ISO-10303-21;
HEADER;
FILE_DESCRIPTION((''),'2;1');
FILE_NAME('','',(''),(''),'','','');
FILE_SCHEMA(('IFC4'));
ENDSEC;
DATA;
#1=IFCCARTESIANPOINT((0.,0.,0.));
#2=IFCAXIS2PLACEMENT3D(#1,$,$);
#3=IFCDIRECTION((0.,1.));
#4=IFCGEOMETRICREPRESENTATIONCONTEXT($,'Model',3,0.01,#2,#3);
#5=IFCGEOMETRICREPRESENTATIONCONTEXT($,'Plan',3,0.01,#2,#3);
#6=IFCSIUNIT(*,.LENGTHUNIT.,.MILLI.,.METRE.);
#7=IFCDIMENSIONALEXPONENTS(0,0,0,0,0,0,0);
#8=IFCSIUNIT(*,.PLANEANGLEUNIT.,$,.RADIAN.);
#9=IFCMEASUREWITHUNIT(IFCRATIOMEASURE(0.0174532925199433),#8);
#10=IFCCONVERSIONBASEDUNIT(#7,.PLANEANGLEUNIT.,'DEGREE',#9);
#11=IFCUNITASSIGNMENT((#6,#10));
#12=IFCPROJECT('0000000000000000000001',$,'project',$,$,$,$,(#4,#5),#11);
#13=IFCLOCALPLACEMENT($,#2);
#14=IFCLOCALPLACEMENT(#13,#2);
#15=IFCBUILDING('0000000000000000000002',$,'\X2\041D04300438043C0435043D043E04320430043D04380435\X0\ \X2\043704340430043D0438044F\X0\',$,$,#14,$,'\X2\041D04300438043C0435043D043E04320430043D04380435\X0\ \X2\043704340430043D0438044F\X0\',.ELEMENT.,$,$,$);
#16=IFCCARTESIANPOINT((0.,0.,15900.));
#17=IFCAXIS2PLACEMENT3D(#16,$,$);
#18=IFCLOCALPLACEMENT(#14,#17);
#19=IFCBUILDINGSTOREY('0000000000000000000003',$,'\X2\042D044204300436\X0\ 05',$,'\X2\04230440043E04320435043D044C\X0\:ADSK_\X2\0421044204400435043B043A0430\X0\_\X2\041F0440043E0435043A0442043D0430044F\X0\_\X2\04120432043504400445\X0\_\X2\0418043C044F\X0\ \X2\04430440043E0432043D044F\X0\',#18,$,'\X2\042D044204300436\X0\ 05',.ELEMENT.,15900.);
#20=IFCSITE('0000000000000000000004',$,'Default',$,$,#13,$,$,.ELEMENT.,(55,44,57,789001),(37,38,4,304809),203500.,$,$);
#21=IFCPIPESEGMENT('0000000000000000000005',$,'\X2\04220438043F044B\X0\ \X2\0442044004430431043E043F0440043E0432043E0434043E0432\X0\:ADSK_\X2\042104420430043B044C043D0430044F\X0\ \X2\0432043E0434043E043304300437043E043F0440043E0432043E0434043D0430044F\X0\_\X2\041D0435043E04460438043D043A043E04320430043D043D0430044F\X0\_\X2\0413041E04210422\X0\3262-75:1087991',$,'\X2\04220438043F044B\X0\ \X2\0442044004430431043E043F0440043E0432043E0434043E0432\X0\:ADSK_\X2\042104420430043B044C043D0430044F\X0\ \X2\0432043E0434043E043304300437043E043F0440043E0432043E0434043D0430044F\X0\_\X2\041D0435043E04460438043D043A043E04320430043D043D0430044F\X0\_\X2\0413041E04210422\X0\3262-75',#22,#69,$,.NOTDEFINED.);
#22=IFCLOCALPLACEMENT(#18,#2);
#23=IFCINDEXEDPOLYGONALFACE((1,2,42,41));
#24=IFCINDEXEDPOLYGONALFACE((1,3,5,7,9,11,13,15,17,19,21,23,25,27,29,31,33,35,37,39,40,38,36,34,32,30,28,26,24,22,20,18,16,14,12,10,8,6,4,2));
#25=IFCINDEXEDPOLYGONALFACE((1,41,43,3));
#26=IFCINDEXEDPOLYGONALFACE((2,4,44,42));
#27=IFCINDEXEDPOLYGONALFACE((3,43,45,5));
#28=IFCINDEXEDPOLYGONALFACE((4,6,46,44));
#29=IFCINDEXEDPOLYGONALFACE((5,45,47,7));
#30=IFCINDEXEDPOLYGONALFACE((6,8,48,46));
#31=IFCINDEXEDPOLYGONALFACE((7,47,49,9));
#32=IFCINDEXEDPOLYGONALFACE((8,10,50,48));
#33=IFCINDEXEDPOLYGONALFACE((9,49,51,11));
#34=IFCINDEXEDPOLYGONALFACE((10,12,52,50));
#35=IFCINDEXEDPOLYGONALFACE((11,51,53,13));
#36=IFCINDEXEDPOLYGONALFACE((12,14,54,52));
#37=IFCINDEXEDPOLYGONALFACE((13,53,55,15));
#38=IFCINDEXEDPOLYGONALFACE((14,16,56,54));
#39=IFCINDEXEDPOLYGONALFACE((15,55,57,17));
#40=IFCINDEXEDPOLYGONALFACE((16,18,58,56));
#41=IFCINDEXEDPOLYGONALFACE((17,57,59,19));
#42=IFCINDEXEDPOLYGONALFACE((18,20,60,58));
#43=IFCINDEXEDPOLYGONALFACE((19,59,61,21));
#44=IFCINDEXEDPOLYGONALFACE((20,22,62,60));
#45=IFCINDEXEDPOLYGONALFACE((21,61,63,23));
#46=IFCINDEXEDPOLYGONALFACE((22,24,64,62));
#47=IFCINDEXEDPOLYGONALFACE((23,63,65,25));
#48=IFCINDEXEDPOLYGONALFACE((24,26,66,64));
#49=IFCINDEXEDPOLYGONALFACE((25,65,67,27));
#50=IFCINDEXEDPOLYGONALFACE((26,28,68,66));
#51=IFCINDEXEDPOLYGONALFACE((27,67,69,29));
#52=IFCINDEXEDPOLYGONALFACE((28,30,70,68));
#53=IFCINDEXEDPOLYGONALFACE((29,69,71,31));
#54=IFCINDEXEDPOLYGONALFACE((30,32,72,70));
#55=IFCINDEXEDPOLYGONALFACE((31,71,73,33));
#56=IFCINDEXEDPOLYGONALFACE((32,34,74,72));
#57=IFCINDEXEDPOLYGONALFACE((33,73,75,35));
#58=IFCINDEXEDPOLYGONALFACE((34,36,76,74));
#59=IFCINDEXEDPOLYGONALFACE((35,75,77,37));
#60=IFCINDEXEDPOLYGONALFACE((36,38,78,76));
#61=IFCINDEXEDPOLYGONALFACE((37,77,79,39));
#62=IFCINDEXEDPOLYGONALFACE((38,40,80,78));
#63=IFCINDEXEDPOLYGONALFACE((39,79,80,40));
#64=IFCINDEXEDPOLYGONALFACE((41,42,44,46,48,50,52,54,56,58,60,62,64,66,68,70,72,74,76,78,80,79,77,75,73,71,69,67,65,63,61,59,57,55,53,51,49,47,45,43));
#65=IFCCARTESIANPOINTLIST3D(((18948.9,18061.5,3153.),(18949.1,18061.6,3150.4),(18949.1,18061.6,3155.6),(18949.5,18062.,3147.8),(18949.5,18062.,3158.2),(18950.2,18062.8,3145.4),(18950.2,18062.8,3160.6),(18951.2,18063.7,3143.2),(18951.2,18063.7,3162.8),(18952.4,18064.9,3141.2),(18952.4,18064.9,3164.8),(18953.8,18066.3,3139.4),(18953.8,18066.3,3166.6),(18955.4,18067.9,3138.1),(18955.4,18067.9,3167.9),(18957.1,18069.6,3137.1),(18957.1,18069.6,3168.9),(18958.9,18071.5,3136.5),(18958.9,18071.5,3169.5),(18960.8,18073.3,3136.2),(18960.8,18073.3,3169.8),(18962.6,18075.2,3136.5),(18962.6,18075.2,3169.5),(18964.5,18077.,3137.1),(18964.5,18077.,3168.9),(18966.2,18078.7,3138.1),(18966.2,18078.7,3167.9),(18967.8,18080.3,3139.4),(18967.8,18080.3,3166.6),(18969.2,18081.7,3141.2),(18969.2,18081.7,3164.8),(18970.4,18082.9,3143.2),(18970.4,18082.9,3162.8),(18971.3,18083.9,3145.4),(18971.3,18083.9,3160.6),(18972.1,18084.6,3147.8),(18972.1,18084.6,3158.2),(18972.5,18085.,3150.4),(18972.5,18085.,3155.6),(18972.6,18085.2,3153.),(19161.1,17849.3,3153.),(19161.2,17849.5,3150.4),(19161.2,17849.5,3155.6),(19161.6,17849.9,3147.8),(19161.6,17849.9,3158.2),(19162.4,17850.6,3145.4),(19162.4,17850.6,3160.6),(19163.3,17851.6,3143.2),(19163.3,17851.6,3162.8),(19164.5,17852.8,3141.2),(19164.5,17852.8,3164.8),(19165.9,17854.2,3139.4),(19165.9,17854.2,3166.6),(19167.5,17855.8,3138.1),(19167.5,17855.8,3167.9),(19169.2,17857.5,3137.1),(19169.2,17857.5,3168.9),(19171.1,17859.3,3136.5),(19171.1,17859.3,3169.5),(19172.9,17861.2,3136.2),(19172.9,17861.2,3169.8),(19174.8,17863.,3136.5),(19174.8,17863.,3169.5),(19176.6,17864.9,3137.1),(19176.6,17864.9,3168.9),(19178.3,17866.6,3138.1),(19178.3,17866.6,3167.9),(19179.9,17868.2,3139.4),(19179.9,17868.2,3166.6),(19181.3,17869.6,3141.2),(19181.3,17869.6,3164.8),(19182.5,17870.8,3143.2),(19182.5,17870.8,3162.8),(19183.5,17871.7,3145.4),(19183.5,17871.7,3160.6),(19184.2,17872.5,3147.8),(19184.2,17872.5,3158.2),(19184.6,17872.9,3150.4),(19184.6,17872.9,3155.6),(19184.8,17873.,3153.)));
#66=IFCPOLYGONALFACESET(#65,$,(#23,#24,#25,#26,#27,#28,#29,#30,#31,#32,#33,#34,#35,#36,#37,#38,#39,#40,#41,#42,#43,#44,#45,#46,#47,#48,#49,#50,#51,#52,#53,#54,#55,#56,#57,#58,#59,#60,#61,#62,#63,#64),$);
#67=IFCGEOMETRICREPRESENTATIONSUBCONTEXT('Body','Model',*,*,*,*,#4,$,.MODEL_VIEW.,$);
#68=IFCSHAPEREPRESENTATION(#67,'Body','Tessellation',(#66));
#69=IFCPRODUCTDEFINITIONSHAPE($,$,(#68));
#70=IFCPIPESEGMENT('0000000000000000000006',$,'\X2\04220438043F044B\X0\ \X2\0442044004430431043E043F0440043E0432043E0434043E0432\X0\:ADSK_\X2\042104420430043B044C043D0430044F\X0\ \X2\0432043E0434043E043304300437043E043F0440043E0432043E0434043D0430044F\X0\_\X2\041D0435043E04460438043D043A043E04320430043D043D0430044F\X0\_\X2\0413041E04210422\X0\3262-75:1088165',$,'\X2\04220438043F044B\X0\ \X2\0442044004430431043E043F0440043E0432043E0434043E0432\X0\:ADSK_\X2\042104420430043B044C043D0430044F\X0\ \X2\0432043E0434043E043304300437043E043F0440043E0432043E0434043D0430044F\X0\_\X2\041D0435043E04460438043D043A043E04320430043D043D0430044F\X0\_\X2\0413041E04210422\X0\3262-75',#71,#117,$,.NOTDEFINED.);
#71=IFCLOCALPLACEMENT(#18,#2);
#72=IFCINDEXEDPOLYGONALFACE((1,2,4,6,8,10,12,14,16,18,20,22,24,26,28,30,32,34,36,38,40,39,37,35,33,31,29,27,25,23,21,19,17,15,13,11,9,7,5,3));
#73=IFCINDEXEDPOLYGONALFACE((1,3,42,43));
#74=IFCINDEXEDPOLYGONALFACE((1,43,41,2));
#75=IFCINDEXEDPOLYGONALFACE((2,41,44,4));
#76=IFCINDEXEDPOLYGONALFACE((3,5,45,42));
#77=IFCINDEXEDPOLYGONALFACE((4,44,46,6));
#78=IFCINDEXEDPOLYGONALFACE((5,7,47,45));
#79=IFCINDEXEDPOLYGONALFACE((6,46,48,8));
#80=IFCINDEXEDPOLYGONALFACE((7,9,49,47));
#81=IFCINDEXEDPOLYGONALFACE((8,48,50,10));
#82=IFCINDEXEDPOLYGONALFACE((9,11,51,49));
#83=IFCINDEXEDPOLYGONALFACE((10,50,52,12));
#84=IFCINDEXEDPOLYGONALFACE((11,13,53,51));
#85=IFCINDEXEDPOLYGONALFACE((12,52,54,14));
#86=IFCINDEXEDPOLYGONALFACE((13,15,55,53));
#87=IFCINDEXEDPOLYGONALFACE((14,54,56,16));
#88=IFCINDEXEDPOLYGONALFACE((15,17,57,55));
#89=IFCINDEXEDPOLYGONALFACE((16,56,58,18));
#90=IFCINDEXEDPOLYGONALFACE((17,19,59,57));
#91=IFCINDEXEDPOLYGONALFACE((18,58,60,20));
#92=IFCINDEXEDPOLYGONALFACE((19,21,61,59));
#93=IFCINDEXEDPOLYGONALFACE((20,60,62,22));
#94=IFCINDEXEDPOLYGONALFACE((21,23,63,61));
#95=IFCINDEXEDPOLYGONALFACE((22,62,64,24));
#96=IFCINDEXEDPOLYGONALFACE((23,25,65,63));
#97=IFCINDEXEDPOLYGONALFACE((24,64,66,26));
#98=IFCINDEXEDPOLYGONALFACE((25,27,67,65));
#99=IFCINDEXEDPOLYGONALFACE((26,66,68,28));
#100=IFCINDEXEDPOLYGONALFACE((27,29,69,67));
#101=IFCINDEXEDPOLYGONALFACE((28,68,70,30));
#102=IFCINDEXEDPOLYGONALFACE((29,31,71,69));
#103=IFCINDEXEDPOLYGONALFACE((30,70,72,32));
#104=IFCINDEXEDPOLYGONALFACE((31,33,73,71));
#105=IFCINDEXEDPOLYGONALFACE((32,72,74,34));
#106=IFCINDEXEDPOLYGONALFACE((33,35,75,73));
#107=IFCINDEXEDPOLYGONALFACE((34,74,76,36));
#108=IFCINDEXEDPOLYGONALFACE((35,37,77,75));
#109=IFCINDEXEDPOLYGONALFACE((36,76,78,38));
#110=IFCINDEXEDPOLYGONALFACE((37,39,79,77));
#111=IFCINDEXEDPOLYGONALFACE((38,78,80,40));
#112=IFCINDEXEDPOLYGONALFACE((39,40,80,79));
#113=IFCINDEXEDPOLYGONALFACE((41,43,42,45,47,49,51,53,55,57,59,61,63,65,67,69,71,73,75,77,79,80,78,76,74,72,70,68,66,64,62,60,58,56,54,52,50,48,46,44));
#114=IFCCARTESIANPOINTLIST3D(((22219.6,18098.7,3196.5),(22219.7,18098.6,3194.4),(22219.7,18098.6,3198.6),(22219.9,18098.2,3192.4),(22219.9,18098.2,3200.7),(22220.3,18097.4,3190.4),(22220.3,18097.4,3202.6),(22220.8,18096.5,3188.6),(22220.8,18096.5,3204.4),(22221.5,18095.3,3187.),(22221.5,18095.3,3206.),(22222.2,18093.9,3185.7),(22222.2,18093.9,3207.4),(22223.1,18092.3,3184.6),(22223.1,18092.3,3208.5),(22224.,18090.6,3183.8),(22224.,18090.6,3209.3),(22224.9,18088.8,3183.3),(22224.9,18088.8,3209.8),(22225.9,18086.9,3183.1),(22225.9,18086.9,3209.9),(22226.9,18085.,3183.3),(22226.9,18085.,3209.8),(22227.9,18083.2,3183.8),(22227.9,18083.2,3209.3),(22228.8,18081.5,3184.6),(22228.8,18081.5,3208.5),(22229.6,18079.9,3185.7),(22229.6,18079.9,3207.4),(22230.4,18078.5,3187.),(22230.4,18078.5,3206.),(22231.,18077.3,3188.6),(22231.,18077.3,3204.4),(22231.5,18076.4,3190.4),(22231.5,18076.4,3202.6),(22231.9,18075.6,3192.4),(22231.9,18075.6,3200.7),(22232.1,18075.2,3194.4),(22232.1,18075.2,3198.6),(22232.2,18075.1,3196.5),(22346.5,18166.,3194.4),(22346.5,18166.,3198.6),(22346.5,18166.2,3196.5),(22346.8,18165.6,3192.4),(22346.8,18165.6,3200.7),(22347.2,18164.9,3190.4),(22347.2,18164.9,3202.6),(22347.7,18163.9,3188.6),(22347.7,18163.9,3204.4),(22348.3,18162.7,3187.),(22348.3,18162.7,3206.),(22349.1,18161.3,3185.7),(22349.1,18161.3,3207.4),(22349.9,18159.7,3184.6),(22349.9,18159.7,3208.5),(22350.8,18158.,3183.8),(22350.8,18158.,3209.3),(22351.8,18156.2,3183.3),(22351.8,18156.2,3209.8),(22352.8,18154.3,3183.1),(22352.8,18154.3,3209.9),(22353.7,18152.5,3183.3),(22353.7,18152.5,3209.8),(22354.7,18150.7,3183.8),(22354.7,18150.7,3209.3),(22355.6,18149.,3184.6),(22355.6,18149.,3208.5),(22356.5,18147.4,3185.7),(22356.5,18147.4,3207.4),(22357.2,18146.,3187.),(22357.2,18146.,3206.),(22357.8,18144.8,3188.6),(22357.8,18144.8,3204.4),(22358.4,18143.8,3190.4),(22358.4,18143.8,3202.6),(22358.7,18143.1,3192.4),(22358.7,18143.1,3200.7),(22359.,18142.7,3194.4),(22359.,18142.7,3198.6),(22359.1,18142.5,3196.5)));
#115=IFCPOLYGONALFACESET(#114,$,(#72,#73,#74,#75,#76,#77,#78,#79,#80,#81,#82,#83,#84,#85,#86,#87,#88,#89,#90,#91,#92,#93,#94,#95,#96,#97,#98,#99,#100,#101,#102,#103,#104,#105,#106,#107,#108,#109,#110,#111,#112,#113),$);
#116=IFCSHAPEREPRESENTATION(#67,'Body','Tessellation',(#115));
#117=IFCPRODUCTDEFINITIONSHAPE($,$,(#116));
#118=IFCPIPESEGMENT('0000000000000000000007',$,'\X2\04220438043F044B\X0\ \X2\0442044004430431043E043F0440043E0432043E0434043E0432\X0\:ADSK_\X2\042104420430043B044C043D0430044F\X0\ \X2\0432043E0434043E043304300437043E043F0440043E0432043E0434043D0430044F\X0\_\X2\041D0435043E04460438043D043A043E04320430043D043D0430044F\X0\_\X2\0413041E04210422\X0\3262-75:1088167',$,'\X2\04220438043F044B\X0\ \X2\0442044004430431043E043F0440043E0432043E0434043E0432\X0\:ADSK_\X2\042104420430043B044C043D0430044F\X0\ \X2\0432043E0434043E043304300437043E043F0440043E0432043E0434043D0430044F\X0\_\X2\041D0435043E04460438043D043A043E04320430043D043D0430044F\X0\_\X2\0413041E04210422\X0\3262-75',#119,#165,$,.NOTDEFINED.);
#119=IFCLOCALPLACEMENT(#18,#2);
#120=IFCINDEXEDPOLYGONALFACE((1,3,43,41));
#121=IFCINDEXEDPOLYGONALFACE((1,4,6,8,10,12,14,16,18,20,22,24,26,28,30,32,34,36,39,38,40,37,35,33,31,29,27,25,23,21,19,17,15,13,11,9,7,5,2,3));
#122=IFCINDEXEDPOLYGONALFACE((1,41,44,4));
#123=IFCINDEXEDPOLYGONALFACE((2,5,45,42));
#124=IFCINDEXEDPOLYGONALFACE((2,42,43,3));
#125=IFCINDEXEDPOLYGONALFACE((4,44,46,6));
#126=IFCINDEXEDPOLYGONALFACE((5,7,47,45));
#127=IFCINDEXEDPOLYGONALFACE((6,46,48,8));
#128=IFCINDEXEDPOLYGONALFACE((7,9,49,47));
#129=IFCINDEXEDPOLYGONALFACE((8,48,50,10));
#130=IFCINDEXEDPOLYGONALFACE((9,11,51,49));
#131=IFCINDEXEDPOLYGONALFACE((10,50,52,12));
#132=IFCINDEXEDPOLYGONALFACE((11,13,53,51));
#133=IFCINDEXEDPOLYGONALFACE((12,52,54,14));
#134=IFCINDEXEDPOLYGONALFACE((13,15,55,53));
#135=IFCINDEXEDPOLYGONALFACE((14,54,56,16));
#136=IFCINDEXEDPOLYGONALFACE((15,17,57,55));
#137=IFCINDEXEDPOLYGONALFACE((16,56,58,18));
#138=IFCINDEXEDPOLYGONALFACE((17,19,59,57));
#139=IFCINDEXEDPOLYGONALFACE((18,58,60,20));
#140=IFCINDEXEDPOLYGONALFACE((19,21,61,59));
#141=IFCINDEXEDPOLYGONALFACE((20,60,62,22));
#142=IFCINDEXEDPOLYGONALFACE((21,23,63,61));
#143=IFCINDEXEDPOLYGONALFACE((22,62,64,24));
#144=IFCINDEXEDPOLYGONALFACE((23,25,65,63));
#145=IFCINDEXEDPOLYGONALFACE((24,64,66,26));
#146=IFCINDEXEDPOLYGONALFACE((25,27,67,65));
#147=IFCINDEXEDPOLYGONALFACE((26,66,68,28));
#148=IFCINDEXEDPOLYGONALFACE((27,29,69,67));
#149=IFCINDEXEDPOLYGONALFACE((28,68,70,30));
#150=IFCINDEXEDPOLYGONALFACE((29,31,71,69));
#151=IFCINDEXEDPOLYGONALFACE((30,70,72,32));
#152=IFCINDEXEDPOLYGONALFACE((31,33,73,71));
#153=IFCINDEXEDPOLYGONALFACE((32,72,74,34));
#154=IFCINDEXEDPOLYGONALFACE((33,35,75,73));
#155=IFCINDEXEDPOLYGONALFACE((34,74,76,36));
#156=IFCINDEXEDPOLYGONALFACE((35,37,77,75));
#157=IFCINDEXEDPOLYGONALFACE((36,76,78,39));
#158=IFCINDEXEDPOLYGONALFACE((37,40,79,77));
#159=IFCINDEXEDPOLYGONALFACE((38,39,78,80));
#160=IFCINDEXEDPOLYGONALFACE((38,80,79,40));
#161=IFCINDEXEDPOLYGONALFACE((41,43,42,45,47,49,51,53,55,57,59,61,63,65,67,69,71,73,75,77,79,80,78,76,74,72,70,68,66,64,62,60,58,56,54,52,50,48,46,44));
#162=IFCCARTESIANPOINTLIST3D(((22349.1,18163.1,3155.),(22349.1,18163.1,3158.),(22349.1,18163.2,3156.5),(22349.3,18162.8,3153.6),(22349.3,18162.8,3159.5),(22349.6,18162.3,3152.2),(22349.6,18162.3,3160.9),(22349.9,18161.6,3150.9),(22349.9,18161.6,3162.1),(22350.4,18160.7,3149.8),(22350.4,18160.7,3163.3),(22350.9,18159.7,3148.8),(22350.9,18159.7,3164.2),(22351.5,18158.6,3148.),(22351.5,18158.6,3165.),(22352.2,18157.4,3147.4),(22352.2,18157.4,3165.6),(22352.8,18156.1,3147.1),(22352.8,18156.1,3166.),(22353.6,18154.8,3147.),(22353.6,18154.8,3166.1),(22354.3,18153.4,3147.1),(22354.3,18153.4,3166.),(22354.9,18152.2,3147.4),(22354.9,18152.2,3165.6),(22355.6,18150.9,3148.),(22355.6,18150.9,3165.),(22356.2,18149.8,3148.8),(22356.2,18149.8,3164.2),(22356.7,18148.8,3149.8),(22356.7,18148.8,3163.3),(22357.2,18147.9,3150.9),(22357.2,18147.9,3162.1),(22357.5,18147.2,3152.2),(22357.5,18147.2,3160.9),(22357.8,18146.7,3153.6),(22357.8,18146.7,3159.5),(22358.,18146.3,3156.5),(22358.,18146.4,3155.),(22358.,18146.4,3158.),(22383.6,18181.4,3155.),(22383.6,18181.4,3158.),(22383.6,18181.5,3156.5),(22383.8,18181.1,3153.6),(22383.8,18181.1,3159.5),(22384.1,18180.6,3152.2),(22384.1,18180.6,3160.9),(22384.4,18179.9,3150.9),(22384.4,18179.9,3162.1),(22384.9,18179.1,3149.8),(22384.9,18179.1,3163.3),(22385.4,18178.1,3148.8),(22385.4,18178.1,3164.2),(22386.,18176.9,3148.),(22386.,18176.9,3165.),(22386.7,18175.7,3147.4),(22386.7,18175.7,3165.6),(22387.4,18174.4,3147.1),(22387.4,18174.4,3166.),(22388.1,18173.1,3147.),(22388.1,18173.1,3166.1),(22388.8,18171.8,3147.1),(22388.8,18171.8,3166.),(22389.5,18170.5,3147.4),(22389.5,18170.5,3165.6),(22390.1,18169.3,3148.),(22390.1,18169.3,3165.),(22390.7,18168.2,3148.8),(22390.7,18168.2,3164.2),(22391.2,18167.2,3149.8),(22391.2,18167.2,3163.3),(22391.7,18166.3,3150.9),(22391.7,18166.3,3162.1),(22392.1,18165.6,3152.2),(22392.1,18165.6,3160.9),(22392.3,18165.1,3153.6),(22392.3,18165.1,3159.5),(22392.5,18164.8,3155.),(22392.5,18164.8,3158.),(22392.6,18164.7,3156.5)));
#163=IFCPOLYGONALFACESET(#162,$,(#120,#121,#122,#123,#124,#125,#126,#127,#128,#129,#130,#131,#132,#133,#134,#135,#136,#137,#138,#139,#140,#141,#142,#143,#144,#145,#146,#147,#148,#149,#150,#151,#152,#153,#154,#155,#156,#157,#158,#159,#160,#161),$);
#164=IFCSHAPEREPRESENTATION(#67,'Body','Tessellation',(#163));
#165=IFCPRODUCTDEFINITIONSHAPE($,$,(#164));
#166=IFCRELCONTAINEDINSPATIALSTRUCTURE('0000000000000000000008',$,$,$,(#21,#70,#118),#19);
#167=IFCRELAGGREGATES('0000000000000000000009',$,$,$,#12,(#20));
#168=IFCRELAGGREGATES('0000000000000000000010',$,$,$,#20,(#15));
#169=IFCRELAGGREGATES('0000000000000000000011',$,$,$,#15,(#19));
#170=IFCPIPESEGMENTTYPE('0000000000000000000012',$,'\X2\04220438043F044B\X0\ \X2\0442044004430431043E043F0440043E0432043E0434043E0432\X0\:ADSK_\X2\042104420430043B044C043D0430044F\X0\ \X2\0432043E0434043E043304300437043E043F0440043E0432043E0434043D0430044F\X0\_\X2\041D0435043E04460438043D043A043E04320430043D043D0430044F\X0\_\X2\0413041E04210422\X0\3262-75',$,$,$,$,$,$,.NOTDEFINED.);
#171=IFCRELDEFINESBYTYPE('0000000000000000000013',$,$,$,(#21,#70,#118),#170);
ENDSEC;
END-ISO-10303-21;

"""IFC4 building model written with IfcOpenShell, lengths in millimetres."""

from ifc_helpers import new_model, entity, si_unit, converted_unit, direction, frame, origin, place, context, subcontext, project, spatial, indexed_curve, outline, extrude, type_object, element, save


model = new_model("IFC4")

# Units and contexts
model_context = context("Model", 3, precision=0.01, world=origin(), true_north=direction((0.0, 1.0)))
plan_context = context("Plan", 3, precision=0.01, world=origin(), true_north=direction((0.0, 1.0)))
body_context = subcontext(model_context, "Body", "Model", "MODEL_VIEW")
ifc_project = project(units=[si_unit("LENGTHUNIT", "METRE", prefix="MILLI"), converted_unit("PLANEANGLEUNIT", "DEGREE", entity("IfcRatioMeasure", 0.0174532925199433), si_unit("PLANEANGLEUNIT", "RADIAN"), dimensions=[0, 0, 0, 0, 0, 0, 0])], contexts=[model_context, plan_context])

# Site, building, storey
site_placement = place(None, origin())
site = spatial("IfcSite", under=ifc_project, at=site_placement, Name="Default", CompositionType="ELEMENT", RefLatitude=(55, 44, 57, 789001), RefLongitude=(37, 38, 4, 304809), RefElevation=203500.0)
building_placement = place(site_placement, origin())
building = spatial("IfcBuilding", under=site, at=building_placement, Name="Наименование здания", LongName="Наименование здания", CompositionType="ELEMENT")
storey_placement = place(building_placement, frame((0.0, 0.0, 15900.0)))
storey = spatial("IfcBuildingStorey", under=building, at=storey_placement, Name="Этаж 05", ObjectType="Уровень:ADSK_Стрелка_Проектная_Вверх_Имя уровня", LongName="Этаж 05", CompositionType="ELEMENT", Elevation=15900.0)

# Pipe segments
placement = place(storey_placement, origin())
pipe_segment_type_1 = type_object("IfcPipeSegmentType", Name="Типы трубопроводов:ADSK_Стальная водогазопроводная_Неоцинкованная_ГОСТ3262-75", PredefinedType="NOTDEFINED")
element("IfcPipeSegment", 1, at=placement, inside=storey, type_object=pipe_segment_type_1, Name="Типы трубопроводов:ADSK_Стальная водогазопроводная_Неоцинкованная_ГОСТ3262-75:1087991", ObjectType="Типы трубопроводов:ADSK_Стальная водогазопроводная_Неоцинкованная_ГОСТ3262-75", PredefinedType="NOTDEFINED", context=body_context, shape_type="SweptSolid", body=[
    extrude(outline(indexed_curve([(16.8, 0.0), (16.5, 2.6), (15.9, 5.2), (14.9, 7.6), (13.6, 9.8), (11.8, 11.8), (9.8, 13.6), (7.6, 14.9), (5.2, 15.9), (2.6, 16.5), (0.0, 16.8), (-2.6, 16.5), (-5.2, 15.9), (-7.6, 14.9), (-9.8, 13.6), (-11.8, 11.8), (-13.6, 9.8), (-14.9, 7.6), (-15.9, 5.2), (-16.5, 2.6), (-16.8, 0.0), (-16.5, -2.6), (-15.9, -5.2), (-14.9, -7.6), (-13.6, -9.8), (-11.8, -11.8), (-9.8, -13.6), (-7.6, -14.9), (-5.2, -15.9), (-2.6, -16.5), (0.0, -16.8), (2.6, -16.5), (5.2, -15.9), (7.6, -14.9), (9.8, -13.6), (11.8, -11.8), (13.6, -9.8), (14.9, -7.6), (15.9, -5.2), (16.5, -2.6), (16.8, 0.0)], self_intersect=False)), frame((19172.9, 17861.2, 3153.0), z_axis=(-0.707107, 0.707107, 0.0), x_axis=(0.707107, 0.707107, 0.0)), (0.0, 0.0, 1.0), 300.0),
])
element("IfcPipeSegment", 2, at=placement, inside=storey, type_object=pipe_segment_type_1, Name="Типы трубопроводов:ADSK_Стальная водогазопроводная_Неоцинкованная_ГОСТ3262-75:1088165", ObjectType="Типы трубопроводов:ADSK_Стальная водогазопроводная_Неоцинкованная_ГОСТ3262-75", PredefinedType="NOTDEFINED", context=body_context, shape_type="SweptSolid", body=[
    extrude(outline(indexed_curve([(13.4, 0.0), (13.2, 2.1), (12.7, 4.1), (11.9, 6.1), (10.8, 7.9), (9.5, 9.5), (7.9, 10.8), (6.1, 11.9), (4.1, 12.7), (2.1, 13.2), (0.0, 13.4), (-2.1, 13.2), (-4.1, 12.7), (-6.1, 11.9), (-7.9, 10.8), (-9.5, 9.5), (-10.8, 7.9), (-11.9, 6.1), (-12.7, 4.1), (-13.2, 2.1), (-13.4, 0.0), (-13.2, -2.1), (-12.7, -4.1), (-11.9, -6.1), (-10.8, -7.9), (-9.5, -9.5), (-7.9, -10.8), (-6.1, -11.9), (-4.1, -12.7), (-2.1, -13.2), (0.0, -13.4), (2.1, -13.2), (4.1, -12.7), (6.1, -11.9), (7.9, -10.8), (9.5, -9.5), (10.8, -7.9), (11.9, -6.1), (12.7, -4.1), (13.2, -2.1), (13.4, 0.0)], self_intersect=False)), frame((22225.9, 18086.9, 3196.5), z_axis=(0.882948, 0.469472, 0.0), x_axis=(0.469472, -0.882948, 0.0)), (0.0, 0.0, 1.0), 143.7),
])
element("IfcPipeSegment", 3, at=placement, inside=storey, type_object=pipe_segment_type_1, Name="Типы трубопроводов:ADSK_Стальная водогазопроводная_Неоцинкованная_ГОСТ3262-75:1088167", ObjectType="Типы трубопроводов:ADSK_Стальная водогазопроводная_Неоцинкованная_ГОСТ3262-75", PredefinedType="NOTDEFINED", context=body_context, shape_type="SweptSolid", body=[
    extrude(outline(indexed_curve([(9.6, 0.0), (9.4, 1.5), (9.1, 3.0), (8.5, 4.3), (7.7, 5.6), (6.8, 6.8), (5.6, 7.7), (4.3, 8.5), (3.0, 9.1), (1.5, 9.4), (0.0, 9.6), (-1.5, 9.4), (-3.0, 9.1), (-4.3, 8.5), (-5.6, 7.7), (-6.8, 6.8), (-7.7, 5.6), (-8.5, 4.3), (-9.1, 3.0), (-9.4, 1.5), (-9.6, 0.0), (-9.4, -1.5), (-9.1, -3.0), (-8.5, -4.3), (-7.7, -5.6), (-6.8, -6.8), (-5.6, -7.7), (-4.3, -8.5), (-3.0, -9.1), (-1.5, -9.4), (0.0, -9.6), (1.5, -9.4), (3.0, -9.1), (4.3, -8.5), (5.6, -7.7), (6.8, -6.8), (7.7, -5.6), (8.5, -4.3), (9.1, -3.0), (9.4, -1.5), (9.6, 0.0)], self_intersect=False)), frame((22353.5, 18154.8, 3156.5), z_axis=(0.882948, 0.469472, 0.0), x_axis=(-0.469472, 0.882948, 0.0)), (0.0, 0.0, 1.0), 39.1),
])

save(model, "model.ifc")
